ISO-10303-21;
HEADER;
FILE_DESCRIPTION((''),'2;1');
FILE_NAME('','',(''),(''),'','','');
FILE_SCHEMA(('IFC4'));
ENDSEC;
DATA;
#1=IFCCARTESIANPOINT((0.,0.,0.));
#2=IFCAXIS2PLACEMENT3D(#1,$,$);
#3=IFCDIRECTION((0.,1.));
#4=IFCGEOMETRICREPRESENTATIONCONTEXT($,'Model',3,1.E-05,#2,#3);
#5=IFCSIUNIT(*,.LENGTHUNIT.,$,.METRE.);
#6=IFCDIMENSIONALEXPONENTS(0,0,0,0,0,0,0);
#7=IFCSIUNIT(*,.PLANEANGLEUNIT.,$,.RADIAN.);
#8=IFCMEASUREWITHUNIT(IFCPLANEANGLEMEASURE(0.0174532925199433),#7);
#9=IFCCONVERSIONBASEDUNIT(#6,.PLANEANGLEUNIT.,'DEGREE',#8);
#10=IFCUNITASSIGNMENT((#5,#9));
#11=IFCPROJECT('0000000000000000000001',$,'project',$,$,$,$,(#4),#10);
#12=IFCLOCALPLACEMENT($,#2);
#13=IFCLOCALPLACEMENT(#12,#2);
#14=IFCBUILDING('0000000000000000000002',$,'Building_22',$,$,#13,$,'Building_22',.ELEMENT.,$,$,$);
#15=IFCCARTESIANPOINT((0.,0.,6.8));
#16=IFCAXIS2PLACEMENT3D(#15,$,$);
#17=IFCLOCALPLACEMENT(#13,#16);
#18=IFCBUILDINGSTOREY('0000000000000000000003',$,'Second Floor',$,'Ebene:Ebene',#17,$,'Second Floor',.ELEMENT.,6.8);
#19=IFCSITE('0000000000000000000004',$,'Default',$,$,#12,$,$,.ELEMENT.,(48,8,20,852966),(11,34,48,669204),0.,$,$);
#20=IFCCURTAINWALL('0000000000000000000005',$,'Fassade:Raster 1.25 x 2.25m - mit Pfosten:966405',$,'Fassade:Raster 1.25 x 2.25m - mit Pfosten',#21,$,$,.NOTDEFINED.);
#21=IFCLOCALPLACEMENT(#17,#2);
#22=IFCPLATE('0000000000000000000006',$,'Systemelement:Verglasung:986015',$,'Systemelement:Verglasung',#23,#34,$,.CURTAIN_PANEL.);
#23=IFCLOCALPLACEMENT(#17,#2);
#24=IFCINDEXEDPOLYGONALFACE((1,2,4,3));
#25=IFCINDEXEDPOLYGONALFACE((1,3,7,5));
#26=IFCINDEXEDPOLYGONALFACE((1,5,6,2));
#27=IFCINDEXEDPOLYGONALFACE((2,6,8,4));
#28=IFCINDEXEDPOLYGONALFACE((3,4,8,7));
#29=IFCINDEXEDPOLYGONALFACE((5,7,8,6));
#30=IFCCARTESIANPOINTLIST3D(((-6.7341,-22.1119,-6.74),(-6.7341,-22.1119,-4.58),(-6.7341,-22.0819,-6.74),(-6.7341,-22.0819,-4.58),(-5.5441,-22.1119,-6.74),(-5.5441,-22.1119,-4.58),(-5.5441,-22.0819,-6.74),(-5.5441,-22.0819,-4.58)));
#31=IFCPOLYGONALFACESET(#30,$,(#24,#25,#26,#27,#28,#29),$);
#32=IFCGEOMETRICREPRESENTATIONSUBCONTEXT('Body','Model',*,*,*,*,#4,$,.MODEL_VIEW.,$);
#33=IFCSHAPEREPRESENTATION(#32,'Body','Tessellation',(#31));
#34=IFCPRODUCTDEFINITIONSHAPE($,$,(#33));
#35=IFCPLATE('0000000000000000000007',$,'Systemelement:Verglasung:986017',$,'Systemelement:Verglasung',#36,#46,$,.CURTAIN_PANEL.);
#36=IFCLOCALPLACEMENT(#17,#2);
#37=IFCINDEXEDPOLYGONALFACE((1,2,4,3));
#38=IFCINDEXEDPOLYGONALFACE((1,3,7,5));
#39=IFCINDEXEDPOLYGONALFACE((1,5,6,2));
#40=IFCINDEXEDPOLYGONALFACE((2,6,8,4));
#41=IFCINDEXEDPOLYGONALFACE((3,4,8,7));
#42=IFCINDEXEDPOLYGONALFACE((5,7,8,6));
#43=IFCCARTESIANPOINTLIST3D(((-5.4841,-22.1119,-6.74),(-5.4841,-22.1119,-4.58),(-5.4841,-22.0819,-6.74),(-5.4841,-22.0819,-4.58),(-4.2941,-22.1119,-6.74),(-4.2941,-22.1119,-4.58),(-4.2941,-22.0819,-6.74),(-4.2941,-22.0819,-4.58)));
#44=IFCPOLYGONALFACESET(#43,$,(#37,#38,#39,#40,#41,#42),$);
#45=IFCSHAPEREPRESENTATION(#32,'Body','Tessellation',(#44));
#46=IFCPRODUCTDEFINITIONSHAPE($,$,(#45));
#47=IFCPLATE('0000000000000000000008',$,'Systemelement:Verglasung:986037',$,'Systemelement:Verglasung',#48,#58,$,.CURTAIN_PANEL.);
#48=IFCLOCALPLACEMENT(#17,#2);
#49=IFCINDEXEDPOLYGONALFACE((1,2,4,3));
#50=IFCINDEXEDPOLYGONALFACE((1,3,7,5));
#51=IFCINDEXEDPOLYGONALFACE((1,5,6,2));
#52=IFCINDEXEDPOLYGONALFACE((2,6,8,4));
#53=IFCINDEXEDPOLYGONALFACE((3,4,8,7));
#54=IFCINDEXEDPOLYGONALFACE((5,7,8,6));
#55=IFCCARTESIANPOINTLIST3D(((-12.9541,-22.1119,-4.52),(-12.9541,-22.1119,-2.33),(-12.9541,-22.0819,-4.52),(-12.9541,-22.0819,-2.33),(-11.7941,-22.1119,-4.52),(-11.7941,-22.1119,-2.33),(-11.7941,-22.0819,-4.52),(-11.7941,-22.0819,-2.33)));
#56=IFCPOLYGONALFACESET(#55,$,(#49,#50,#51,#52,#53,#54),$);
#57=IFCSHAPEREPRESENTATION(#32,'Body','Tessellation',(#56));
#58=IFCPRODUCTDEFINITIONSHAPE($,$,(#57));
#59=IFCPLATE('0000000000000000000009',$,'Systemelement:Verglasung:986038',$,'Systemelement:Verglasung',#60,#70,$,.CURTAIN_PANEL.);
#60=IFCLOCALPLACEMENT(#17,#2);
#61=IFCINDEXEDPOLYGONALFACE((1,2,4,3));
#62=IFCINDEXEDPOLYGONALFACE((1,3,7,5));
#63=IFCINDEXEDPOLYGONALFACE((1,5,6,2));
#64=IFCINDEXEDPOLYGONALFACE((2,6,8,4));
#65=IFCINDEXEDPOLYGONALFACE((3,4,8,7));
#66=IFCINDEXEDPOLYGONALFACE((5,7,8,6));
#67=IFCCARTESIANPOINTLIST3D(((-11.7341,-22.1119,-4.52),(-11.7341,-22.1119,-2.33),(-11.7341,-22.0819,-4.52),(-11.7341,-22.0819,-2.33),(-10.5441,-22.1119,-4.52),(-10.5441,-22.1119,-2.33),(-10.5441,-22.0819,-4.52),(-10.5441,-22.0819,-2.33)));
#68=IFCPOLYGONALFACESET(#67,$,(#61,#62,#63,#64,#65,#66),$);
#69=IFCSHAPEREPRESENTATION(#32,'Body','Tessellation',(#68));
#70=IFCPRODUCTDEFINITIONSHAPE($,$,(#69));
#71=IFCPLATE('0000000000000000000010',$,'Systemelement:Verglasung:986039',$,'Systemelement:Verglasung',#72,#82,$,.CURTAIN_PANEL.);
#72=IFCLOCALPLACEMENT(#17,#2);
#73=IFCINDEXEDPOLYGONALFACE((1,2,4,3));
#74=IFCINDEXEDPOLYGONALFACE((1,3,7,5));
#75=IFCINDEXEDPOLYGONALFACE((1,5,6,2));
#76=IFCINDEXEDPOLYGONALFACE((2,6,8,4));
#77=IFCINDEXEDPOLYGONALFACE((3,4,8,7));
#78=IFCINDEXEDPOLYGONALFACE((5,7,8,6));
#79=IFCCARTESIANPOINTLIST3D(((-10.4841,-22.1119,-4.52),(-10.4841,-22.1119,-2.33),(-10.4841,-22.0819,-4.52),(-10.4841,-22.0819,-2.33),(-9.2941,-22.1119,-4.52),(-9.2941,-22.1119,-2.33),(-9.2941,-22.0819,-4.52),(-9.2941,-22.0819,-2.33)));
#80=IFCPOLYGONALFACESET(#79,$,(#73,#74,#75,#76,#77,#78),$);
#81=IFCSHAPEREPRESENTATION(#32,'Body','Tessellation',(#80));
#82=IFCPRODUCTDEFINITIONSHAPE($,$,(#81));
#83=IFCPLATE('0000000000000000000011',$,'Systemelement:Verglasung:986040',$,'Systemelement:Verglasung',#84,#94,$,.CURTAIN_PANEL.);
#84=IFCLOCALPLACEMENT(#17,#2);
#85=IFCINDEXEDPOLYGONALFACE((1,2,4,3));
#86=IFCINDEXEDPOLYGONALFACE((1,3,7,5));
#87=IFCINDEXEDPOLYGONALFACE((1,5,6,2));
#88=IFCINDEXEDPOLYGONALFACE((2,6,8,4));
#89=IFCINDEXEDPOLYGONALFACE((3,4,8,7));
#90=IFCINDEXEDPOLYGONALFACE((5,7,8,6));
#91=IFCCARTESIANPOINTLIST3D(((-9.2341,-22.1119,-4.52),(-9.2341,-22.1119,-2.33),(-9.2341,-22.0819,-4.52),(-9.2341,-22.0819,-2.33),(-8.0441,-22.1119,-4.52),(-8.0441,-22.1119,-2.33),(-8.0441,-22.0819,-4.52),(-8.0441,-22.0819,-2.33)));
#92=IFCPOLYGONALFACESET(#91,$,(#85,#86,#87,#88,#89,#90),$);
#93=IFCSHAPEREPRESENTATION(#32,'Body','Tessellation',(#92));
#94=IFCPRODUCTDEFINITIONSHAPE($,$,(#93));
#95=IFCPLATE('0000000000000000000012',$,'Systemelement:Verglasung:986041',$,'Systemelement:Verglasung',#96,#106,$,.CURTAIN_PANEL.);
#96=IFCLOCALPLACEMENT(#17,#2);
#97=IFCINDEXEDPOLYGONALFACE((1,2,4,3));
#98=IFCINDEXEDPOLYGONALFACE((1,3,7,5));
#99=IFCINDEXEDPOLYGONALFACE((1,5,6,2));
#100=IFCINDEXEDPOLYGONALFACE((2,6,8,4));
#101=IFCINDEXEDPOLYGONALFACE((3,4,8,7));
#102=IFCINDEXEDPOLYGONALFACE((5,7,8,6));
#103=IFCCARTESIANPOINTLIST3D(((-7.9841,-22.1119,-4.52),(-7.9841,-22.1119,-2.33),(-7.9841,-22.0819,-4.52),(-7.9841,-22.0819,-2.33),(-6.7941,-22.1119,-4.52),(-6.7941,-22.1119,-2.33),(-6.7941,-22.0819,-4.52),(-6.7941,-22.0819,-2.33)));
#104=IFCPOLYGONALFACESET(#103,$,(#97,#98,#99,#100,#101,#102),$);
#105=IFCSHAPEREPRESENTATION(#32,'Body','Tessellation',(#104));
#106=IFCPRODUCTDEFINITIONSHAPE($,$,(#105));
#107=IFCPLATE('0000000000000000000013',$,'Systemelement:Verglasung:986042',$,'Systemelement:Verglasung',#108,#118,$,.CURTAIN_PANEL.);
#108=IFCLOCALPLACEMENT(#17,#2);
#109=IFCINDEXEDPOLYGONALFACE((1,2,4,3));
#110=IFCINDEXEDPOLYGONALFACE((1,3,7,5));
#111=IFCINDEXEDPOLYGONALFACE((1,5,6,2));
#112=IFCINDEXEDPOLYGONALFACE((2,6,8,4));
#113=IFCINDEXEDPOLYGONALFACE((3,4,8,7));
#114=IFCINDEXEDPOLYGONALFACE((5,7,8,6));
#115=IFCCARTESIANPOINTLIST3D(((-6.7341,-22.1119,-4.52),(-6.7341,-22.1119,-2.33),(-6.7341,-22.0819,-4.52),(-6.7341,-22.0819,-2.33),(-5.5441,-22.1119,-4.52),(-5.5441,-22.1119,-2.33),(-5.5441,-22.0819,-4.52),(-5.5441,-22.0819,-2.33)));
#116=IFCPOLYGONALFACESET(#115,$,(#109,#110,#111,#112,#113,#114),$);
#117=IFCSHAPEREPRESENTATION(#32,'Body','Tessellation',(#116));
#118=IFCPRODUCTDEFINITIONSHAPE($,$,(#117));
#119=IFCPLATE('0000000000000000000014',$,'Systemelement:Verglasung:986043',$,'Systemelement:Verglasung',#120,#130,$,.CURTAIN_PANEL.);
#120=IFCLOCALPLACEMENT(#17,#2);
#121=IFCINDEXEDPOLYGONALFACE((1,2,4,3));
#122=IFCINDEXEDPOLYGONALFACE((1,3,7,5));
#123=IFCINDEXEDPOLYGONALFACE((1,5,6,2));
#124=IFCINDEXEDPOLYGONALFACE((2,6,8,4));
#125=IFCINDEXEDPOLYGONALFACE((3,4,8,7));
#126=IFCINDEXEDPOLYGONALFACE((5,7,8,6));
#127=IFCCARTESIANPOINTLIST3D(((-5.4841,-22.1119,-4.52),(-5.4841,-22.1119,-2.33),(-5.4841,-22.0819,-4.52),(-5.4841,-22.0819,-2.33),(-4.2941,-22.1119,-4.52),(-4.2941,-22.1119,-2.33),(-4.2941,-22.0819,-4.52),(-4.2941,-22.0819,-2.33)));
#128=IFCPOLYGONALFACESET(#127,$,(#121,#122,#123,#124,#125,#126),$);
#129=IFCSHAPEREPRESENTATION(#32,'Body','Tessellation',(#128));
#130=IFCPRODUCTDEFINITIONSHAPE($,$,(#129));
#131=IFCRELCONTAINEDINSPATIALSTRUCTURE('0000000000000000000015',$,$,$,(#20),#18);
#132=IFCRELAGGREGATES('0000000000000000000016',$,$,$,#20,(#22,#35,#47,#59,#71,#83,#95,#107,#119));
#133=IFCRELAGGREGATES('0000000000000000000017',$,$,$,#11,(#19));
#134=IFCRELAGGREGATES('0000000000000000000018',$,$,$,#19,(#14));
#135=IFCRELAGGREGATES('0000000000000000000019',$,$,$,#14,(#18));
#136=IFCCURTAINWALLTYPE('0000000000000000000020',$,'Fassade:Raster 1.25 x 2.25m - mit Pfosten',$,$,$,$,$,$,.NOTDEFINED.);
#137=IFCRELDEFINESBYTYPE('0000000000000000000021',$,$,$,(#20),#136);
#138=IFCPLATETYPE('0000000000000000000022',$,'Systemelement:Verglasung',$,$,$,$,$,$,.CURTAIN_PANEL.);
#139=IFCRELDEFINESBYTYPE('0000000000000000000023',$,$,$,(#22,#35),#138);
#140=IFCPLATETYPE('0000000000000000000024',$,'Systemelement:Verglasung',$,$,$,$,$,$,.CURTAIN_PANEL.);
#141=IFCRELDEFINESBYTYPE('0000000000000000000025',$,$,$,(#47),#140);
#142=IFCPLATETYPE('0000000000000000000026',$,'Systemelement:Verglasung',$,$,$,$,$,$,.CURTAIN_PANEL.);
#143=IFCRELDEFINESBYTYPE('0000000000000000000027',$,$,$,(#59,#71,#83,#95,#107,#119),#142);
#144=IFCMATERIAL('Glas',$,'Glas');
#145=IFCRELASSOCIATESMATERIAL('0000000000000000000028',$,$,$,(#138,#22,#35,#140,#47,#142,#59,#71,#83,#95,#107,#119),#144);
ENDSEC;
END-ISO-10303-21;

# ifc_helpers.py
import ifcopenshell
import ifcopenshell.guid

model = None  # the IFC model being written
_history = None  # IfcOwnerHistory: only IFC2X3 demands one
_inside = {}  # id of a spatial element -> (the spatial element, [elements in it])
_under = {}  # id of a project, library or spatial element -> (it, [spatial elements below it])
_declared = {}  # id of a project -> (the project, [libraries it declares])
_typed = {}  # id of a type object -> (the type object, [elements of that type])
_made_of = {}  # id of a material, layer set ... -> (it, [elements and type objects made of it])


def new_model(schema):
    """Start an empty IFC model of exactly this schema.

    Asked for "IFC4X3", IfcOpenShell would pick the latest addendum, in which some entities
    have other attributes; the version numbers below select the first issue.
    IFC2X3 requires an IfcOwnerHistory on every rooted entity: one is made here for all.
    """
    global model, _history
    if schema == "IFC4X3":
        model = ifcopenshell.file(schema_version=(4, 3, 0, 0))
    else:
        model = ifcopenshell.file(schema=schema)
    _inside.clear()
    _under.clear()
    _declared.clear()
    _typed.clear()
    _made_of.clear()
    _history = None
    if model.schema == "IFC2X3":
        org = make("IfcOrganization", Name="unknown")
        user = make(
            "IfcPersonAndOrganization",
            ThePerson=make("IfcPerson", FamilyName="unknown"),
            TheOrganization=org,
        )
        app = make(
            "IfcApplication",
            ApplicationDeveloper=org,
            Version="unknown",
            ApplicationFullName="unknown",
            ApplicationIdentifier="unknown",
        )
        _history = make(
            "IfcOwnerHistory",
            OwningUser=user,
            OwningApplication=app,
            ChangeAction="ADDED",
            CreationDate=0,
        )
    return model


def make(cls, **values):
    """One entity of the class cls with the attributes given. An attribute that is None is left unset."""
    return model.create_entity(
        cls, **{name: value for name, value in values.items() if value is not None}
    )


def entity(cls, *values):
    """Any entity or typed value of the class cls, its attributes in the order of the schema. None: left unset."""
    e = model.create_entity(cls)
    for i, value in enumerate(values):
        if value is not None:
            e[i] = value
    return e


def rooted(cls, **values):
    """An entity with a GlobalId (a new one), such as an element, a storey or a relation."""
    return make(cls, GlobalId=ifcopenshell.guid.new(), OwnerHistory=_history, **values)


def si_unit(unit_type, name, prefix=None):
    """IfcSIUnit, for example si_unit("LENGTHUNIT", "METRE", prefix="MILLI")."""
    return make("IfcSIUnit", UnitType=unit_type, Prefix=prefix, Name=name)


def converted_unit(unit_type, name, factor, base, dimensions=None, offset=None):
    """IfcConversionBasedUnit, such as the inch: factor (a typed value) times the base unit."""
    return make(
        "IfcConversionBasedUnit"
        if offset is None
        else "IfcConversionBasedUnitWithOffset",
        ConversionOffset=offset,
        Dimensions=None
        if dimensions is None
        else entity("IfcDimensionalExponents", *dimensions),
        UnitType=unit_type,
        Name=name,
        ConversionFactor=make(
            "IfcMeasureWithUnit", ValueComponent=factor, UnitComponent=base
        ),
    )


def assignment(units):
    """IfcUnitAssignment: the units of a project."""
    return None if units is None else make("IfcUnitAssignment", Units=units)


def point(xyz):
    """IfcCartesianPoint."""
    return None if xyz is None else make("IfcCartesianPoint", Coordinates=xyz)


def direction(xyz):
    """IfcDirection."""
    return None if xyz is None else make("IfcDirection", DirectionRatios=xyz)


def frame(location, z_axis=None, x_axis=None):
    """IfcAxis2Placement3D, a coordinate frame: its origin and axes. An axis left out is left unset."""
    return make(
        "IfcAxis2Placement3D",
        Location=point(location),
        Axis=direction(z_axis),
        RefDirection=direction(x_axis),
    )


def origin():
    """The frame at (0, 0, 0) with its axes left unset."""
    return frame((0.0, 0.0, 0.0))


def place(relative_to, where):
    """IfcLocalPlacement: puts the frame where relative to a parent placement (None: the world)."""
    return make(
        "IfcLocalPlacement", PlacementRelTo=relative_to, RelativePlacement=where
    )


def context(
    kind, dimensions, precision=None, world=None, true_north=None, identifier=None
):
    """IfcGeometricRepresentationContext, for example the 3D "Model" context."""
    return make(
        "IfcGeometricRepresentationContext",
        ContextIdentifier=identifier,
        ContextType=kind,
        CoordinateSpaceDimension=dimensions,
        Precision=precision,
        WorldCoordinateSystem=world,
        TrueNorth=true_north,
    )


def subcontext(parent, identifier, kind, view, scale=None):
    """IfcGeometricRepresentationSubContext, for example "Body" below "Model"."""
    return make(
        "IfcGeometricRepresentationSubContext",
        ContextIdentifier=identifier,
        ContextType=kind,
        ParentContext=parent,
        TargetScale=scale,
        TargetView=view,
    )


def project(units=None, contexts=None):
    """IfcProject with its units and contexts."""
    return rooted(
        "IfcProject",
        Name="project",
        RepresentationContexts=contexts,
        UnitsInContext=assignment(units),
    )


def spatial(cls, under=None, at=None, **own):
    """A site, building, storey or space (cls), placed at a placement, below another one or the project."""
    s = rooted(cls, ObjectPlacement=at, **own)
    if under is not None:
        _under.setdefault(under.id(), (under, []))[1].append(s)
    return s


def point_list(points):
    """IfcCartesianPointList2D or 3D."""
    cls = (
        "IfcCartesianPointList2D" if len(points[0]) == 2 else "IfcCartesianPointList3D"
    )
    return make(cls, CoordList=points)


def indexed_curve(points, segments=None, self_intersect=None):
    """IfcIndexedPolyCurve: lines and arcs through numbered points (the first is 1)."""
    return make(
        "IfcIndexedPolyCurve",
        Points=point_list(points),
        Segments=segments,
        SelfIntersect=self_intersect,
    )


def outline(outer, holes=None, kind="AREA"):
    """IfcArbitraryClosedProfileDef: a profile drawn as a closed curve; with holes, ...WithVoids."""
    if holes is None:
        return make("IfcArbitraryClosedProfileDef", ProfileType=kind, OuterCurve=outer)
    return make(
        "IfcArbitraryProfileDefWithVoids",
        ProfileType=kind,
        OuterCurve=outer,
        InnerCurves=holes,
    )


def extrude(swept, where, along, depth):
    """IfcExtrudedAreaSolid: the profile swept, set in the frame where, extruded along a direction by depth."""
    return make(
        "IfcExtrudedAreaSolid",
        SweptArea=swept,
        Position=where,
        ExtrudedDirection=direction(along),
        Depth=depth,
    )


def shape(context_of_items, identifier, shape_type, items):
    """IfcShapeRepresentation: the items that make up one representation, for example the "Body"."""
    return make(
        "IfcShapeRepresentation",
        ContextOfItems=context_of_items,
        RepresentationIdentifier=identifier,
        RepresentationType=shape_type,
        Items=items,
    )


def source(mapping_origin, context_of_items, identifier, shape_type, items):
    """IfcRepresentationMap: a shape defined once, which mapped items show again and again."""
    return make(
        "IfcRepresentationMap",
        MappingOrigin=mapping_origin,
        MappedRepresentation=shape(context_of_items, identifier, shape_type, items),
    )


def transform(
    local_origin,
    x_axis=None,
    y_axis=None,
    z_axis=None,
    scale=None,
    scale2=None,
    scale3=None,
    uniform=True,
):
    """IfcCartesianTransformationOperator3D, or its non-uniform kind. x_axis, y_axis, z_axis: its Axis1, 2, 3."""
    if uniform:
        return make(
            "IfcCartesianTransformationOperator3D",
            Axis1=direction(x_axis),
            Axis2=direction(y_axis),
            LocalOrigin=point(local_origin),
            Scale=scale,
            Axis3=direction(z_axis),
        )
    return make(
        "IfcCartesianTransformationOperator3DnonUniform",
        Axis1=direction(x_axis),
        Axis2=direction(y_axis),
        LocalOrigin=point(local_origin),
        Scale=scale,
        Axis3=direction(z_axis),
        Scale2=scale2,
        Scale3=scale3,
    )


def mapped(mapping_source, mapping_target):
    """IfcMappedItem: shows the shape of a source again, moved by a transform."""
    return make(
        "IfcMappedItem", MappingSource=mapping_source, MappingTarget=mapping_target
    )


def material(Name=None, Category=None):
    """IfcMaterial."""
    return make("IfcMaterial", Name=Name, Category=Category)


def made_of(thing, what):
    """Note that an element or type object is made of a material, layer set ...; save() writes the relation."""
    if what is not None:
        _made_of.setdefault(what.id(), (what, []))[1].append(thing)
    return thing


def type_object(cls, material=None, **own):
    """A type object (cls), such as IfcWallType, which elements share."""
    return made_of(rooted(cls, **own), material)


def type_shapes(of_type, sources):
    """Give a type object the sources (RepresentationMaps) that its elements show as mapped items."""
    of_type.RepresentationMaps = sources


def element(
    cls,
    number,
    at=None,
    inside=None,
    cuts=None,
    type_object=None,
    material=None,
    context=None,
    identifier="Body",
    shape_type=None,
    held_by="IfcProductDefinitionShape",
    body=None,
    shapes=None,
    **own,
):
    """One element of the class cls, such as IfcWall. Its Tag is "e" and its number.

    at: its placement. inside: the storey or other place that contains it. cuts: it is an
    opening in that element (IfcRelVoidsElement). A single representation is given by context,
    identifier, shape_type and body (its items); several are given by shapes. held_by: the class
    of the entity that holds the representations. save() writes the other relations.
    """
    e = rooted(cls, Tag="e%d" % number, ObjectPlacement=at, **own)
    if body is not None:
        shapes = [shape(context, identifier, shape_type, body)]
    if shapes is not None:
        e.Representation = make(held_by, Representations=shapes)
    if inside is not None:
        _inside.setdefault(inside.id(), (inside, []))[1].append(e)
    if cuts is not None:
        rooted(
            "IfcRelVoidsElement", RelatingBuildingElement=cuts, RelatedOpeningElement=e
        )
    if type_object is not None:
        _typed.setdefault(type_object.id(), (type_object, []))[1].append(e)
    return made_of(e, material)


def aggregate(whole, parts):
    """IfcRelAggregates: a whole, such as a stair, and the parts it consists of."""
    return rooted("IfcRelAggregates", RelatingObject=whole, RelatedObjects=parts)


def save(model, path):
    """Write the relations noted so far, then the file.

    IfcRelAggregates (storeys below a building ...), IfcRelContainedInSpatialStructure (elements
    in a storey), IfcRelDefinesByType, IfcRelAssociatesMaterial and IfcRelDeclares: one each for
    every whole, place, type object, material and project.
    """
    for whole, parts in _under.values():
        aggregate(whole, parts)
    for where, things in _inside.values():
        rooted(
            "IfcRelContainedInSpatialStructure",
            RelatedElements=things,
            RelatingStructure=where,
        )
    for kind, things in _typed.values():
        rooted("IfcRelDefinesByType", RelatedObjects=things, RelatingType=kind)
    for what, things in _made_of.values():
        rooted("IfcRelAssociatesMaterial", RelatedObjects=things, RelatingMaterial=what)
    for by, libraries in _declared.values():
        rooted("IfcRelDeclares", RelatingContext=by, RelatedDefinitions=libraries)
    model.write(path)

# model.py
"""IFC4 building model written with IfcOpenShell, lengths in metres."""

from ifc_helpers import new_model, entity, si_unit, converted_unit, direction, frame, origin, place, context, subcontext, project, spatial, indexed_curve, outline, extrude, source, transform, mapped, material, type_object, type_shapes, element, aggregate, save


model = new_model("IFC4")

# Units and contexts
model_context = context("Model", 3, precision=1e-05, world=origin(), true_north=direction((0.0, 1.0)))
body_context = subcontext(model_context, "Body", "Model", "MODEL_VIEW")
ifc_project = project(units=[si_unit("LENGTHUNIT", "METRE"), converted_unit("PLANEANGLEUNIT", "DEGREE", entity("IfcPlaneAngleMeasure", 0.0174532925199433), si_unit("PLANEANGLEUNIT", "RADIAN"), dimensions=[0, 0, 0, 0, 0, 0, 0])], contexts=[model_context])

# Site, building, storey
site_placement = place(None, origin())
site = spatial("IfcSite", under=ifc_project, at=site_placement, Name="Default", CompositionType="ELEMENT", RefLatitude=(48, 8, 20, 852966), RefLongitude=(11, 34, 48, 669204), RefElevation=0.0)
building_placement = place(site_placement, origin())
building = spatial("IfcBuilding", under=site, at=building_placement, Name="Building_22", LongName="Building_22", CompositionType="ELEMENT")
storey_placement = place(building_placement, frame((0.0, 0.0, 6.8)))
storey = spatial("IfcBuildingStorey", under=building, at=storey_placement, Name="Second Floor", ObjectType="Ebene:Ebene", LongName="Second Floor", CompositionType="ELEMENT", Elevation=6.8)

# Curtain wall, plates
curtain_wall_type = type_object("IfcCurtainWallType", Name="Fassade:Raster 1.25 x 2.25m - mit Pfosten", PredefinedType="NOTDEFINED")
curtain_wall_placement = place(storey_placement, frame((0.0, 0.0, -6.8)))
curtain_wall = element("IfcCurtainWall", 1, at=curtain_wall_placement, inside=storey, type_object=curtain_wall_type, Name="Fassade:Raster 1.25 x 2.25m - mit Pfosten:966405", ObjectType="Fassade:Raster 1.25 x 2.25m - mit Pfosten", PredefinedType="NOTDEFINED")
ifc_material_1 = material(Name="Glas", Category="Glas")
plate_type_1 = type_object("IfcPlateType", Name="Systemelement:Verglasung", PredefinedType="CURTAIN_PANEL", material=ifc_material_1)
shared_shape_1 = source(origin(), body_context, "Body", "SweptSolid", [
    extrude(outline(indexed_curve([(-0.015, -0.595), (0.015, -0.595), (0.015, 0.595), (-0.015, 0.595), (-0.015, -0.595)], self_intersect=False)), frame((0.0, 0.0, 0.0), z_axis=(0.0, 0.0, 1.0), x_axis=(0.0, 1.0, 0.0)), (0.0, 0.0, 1.0), 2.16),
])
type_shapes(plate_type_1, [shared_shape_1])
plate_1_placement = place(curtain_wall_placement, frame((-6.1391, -22.0969, 0.06)))
plate_1 = element("IfcPlate", 2, at=plate_1_placement, type_object=plate_type_1, material=ifc_material_1, Name="Systemelement:Verglasung:986015", ObjectType="Systemelement:Verglasung", PredefinedType="CURTAIN_PANEL", context=body_context, shape_type="MappedRepresentation", body=[
    mapped(shared_shape_1, transform((0.0, 0.0, 0.0), scale=1.0)),
])
plate_2_placement = place(curtain_wall_placement, frame((-4.8891, -22.0969, 0.06)))
plate_2 = element("IfcPlate", 3, at=plate_2_placement, type_object=plate_type_1, material=ifc_material_1, Name="Systemelement:Verglasung:986017", ObjectType="Systemelement:Verglasung", PredefinedType="CURTAIN_PANEL", context=body_context, shape_type="MappedRepresentation", body=[
    mapped(shared_shape_1, transform((0.0, 0.0, 0.0), scale=1.0)),
])
plate_type_2 = type_object("IfcPlateType", Name="Systemelement:Verglasung", PredefinedType="CURTAIN_PANEL", material=ifc_material_1)
shared_shape_2 = source(origin(), body_context, "Body", "SweptSolid", [
    extrude(outline(indexed_curve([(-0.015, -0.58), (0.015, -0.58), (0.015, 0.58), (-0.015, 0.58), (-0.015, -0.58)], self_intersect=False)), frame((0.0, 0.0, 0.0), z_axis=(0.0, 0.0, 1.0), x_axis=(0.0, 1.0, 0.0)), (0.0, 0.0, 1.0), 2.19),
])
type_shapes(plate_type_2, [shared_shape_2])
plate_3_placement = place(curtain_wall_placement, frame((-12.3741, -22.0969, 2.28)))
plate_3 = element("IfcPlate", 4, at=plate_3_placement, type_object=plate_type_2, material=ifc_material_1, Name="Systemelement:Verglasung:986037", ObjectType="Systemelement:Verglasung", PredefinedType="CURTAIN_PANEL", context=body_context, shape_type="MappedRepresentation", body=[
    mapped(shared_shape_2, transform((0.0, 0.0, 0.0), scale=1.0)),
])
plate_type_3 = type_object("IfcPlateType", Name="Systemelement:Verglasung", PredefinedType="CURTAIN_PANEL", material=ifc_material_1)
shared_shape_3 = source(origin(), body_context, "Body", "SweptSolid", [
    extrude(outline(indexed_curve([(-0.015, -0.595), (0.015, -0.595), (0.015, 0.595), (-0.015, 0.595), (-0.015, -0.595)], self_intersect=False)), frame((0.0, 0.0, 0.0), z_axis=(0.0, 0.0, 1.0), x_axis=(0.0, 1.0, 0.0)), (0.0, 0.0, 1.0), 2.19),
])
type_shapes(plate_type_3, [shared_shape_3])
plate_4_placement = place(curtain_wall_placement, frame((-11.1391, -22.0969, 2.28)))
plate_4 = element("IfcPlate", 5, at=plate_4_placement, type_object=plate_type_3, material=ifc_material_1, Name="Systemelement:Verglasung:986038", ObjectType="Systemelement:Verglasung", PredefinedType="CURTAIN_PANEL", context=body_context, shape_type="MappedRepresentation", body=[
    mapped(shared_shape_3, transform((0.0, 0.0, 0.0), scale=1.0)),
])
plate_5_placement = place(curtain_wall_placement, frame((-9.8891, -22.0969, 2.28)))
plate_5 = element("IfcPlate", 6, at=plate_5_placement, type_object=plate_type_3, material=ifc_material_1, Name="Systemelement:Verglasung:986039", ObjectType="Systemelement:Verglasung", PredefinedType="CURTAIN_PANEL", context=body_context, shape_type="MappedRepresentation", body=[
    mapped(shared_shape_3, transform((0.0, 0.0, 0.0), scale=1.0)),
])
plate_6_placement = place(curtain_wall_placement, frame((-8.6391, -22.0969, 2.28)))
plate_6 = element("IfcPlate", 7, at=plate_6_placement, type_object=plate_type_3, material=ifc_material_1, Name="Systemelement:Verglasung:986040", ObjectType="Systemelement:Verglasung", PredefinedType="CURTAIN_PANEL", context=body_context, shape_type="MappedRepresentation", body=[
    mapped(shared_shape_3, transform((0.0, 0.0, 0.0), scale=1.0)),
])
plate_7_placement = place(curtain_wall_placement, frame((-7.3891, -22.0969, 2.28)))
plate_7 = element("IfcPlate", 8, at=plate_7_placement, type_object=plate_type_3, material=ifc_material_1, Name="Systemelement:Verglasung:986041", ObjectType="Systemelement:Verglasung", PredefinedType="CURTAIN_PANEL", context=body_context, shape_type="MappedRepresentation", body=[
    mapped(shared_shape_3, transform((0.0, 0.0, 0.0), scale=1.0)),
])
plate_8_placement = place(curtain_wall_placement, frame((-6.1391, -22.0969, 2.28)))
plate_8 = element("IfcPlate", 9, at=plate_8_placement, type_object=plate_type_3, material=ifc_material_1, Name="Systemelement:Verglasung:986042", ObjectType="Systemelement:Verglasung", PredefinedType="CURTAIN_PANEL", context=body_context, shape_type="MappedRepresentation", body=[
    mapped(shared_shape_3, transform((0.0, 0.0, 0.0), scale=1.0)),
])
plate_9_placement = place(curtain_wall_placement, frame((-4.8891, -22.0969, 2.28)))
plate_9 = element("IfcPlate", 10, at=plate_9_placement, type_object=plate_type_3, material=ifc_material_1, Name="Systemelement:Verglasung:986043", ObjectType="Systemelement:Verglasung", PredefinedType="CURTAIN_PANEL", context=body_context, shape_type="MappedRepresentation", body=[
    mapped(shared_shape_3, transform((0.0, 0.0, 0.0), scale=1.0)),
])
aggregate(curtain_wall, [plate_1, plate_2, plate_3, plate_4, plate_5, plate_6, plate_7, plate_8, plate_9])

save(model, "model.ifc")
